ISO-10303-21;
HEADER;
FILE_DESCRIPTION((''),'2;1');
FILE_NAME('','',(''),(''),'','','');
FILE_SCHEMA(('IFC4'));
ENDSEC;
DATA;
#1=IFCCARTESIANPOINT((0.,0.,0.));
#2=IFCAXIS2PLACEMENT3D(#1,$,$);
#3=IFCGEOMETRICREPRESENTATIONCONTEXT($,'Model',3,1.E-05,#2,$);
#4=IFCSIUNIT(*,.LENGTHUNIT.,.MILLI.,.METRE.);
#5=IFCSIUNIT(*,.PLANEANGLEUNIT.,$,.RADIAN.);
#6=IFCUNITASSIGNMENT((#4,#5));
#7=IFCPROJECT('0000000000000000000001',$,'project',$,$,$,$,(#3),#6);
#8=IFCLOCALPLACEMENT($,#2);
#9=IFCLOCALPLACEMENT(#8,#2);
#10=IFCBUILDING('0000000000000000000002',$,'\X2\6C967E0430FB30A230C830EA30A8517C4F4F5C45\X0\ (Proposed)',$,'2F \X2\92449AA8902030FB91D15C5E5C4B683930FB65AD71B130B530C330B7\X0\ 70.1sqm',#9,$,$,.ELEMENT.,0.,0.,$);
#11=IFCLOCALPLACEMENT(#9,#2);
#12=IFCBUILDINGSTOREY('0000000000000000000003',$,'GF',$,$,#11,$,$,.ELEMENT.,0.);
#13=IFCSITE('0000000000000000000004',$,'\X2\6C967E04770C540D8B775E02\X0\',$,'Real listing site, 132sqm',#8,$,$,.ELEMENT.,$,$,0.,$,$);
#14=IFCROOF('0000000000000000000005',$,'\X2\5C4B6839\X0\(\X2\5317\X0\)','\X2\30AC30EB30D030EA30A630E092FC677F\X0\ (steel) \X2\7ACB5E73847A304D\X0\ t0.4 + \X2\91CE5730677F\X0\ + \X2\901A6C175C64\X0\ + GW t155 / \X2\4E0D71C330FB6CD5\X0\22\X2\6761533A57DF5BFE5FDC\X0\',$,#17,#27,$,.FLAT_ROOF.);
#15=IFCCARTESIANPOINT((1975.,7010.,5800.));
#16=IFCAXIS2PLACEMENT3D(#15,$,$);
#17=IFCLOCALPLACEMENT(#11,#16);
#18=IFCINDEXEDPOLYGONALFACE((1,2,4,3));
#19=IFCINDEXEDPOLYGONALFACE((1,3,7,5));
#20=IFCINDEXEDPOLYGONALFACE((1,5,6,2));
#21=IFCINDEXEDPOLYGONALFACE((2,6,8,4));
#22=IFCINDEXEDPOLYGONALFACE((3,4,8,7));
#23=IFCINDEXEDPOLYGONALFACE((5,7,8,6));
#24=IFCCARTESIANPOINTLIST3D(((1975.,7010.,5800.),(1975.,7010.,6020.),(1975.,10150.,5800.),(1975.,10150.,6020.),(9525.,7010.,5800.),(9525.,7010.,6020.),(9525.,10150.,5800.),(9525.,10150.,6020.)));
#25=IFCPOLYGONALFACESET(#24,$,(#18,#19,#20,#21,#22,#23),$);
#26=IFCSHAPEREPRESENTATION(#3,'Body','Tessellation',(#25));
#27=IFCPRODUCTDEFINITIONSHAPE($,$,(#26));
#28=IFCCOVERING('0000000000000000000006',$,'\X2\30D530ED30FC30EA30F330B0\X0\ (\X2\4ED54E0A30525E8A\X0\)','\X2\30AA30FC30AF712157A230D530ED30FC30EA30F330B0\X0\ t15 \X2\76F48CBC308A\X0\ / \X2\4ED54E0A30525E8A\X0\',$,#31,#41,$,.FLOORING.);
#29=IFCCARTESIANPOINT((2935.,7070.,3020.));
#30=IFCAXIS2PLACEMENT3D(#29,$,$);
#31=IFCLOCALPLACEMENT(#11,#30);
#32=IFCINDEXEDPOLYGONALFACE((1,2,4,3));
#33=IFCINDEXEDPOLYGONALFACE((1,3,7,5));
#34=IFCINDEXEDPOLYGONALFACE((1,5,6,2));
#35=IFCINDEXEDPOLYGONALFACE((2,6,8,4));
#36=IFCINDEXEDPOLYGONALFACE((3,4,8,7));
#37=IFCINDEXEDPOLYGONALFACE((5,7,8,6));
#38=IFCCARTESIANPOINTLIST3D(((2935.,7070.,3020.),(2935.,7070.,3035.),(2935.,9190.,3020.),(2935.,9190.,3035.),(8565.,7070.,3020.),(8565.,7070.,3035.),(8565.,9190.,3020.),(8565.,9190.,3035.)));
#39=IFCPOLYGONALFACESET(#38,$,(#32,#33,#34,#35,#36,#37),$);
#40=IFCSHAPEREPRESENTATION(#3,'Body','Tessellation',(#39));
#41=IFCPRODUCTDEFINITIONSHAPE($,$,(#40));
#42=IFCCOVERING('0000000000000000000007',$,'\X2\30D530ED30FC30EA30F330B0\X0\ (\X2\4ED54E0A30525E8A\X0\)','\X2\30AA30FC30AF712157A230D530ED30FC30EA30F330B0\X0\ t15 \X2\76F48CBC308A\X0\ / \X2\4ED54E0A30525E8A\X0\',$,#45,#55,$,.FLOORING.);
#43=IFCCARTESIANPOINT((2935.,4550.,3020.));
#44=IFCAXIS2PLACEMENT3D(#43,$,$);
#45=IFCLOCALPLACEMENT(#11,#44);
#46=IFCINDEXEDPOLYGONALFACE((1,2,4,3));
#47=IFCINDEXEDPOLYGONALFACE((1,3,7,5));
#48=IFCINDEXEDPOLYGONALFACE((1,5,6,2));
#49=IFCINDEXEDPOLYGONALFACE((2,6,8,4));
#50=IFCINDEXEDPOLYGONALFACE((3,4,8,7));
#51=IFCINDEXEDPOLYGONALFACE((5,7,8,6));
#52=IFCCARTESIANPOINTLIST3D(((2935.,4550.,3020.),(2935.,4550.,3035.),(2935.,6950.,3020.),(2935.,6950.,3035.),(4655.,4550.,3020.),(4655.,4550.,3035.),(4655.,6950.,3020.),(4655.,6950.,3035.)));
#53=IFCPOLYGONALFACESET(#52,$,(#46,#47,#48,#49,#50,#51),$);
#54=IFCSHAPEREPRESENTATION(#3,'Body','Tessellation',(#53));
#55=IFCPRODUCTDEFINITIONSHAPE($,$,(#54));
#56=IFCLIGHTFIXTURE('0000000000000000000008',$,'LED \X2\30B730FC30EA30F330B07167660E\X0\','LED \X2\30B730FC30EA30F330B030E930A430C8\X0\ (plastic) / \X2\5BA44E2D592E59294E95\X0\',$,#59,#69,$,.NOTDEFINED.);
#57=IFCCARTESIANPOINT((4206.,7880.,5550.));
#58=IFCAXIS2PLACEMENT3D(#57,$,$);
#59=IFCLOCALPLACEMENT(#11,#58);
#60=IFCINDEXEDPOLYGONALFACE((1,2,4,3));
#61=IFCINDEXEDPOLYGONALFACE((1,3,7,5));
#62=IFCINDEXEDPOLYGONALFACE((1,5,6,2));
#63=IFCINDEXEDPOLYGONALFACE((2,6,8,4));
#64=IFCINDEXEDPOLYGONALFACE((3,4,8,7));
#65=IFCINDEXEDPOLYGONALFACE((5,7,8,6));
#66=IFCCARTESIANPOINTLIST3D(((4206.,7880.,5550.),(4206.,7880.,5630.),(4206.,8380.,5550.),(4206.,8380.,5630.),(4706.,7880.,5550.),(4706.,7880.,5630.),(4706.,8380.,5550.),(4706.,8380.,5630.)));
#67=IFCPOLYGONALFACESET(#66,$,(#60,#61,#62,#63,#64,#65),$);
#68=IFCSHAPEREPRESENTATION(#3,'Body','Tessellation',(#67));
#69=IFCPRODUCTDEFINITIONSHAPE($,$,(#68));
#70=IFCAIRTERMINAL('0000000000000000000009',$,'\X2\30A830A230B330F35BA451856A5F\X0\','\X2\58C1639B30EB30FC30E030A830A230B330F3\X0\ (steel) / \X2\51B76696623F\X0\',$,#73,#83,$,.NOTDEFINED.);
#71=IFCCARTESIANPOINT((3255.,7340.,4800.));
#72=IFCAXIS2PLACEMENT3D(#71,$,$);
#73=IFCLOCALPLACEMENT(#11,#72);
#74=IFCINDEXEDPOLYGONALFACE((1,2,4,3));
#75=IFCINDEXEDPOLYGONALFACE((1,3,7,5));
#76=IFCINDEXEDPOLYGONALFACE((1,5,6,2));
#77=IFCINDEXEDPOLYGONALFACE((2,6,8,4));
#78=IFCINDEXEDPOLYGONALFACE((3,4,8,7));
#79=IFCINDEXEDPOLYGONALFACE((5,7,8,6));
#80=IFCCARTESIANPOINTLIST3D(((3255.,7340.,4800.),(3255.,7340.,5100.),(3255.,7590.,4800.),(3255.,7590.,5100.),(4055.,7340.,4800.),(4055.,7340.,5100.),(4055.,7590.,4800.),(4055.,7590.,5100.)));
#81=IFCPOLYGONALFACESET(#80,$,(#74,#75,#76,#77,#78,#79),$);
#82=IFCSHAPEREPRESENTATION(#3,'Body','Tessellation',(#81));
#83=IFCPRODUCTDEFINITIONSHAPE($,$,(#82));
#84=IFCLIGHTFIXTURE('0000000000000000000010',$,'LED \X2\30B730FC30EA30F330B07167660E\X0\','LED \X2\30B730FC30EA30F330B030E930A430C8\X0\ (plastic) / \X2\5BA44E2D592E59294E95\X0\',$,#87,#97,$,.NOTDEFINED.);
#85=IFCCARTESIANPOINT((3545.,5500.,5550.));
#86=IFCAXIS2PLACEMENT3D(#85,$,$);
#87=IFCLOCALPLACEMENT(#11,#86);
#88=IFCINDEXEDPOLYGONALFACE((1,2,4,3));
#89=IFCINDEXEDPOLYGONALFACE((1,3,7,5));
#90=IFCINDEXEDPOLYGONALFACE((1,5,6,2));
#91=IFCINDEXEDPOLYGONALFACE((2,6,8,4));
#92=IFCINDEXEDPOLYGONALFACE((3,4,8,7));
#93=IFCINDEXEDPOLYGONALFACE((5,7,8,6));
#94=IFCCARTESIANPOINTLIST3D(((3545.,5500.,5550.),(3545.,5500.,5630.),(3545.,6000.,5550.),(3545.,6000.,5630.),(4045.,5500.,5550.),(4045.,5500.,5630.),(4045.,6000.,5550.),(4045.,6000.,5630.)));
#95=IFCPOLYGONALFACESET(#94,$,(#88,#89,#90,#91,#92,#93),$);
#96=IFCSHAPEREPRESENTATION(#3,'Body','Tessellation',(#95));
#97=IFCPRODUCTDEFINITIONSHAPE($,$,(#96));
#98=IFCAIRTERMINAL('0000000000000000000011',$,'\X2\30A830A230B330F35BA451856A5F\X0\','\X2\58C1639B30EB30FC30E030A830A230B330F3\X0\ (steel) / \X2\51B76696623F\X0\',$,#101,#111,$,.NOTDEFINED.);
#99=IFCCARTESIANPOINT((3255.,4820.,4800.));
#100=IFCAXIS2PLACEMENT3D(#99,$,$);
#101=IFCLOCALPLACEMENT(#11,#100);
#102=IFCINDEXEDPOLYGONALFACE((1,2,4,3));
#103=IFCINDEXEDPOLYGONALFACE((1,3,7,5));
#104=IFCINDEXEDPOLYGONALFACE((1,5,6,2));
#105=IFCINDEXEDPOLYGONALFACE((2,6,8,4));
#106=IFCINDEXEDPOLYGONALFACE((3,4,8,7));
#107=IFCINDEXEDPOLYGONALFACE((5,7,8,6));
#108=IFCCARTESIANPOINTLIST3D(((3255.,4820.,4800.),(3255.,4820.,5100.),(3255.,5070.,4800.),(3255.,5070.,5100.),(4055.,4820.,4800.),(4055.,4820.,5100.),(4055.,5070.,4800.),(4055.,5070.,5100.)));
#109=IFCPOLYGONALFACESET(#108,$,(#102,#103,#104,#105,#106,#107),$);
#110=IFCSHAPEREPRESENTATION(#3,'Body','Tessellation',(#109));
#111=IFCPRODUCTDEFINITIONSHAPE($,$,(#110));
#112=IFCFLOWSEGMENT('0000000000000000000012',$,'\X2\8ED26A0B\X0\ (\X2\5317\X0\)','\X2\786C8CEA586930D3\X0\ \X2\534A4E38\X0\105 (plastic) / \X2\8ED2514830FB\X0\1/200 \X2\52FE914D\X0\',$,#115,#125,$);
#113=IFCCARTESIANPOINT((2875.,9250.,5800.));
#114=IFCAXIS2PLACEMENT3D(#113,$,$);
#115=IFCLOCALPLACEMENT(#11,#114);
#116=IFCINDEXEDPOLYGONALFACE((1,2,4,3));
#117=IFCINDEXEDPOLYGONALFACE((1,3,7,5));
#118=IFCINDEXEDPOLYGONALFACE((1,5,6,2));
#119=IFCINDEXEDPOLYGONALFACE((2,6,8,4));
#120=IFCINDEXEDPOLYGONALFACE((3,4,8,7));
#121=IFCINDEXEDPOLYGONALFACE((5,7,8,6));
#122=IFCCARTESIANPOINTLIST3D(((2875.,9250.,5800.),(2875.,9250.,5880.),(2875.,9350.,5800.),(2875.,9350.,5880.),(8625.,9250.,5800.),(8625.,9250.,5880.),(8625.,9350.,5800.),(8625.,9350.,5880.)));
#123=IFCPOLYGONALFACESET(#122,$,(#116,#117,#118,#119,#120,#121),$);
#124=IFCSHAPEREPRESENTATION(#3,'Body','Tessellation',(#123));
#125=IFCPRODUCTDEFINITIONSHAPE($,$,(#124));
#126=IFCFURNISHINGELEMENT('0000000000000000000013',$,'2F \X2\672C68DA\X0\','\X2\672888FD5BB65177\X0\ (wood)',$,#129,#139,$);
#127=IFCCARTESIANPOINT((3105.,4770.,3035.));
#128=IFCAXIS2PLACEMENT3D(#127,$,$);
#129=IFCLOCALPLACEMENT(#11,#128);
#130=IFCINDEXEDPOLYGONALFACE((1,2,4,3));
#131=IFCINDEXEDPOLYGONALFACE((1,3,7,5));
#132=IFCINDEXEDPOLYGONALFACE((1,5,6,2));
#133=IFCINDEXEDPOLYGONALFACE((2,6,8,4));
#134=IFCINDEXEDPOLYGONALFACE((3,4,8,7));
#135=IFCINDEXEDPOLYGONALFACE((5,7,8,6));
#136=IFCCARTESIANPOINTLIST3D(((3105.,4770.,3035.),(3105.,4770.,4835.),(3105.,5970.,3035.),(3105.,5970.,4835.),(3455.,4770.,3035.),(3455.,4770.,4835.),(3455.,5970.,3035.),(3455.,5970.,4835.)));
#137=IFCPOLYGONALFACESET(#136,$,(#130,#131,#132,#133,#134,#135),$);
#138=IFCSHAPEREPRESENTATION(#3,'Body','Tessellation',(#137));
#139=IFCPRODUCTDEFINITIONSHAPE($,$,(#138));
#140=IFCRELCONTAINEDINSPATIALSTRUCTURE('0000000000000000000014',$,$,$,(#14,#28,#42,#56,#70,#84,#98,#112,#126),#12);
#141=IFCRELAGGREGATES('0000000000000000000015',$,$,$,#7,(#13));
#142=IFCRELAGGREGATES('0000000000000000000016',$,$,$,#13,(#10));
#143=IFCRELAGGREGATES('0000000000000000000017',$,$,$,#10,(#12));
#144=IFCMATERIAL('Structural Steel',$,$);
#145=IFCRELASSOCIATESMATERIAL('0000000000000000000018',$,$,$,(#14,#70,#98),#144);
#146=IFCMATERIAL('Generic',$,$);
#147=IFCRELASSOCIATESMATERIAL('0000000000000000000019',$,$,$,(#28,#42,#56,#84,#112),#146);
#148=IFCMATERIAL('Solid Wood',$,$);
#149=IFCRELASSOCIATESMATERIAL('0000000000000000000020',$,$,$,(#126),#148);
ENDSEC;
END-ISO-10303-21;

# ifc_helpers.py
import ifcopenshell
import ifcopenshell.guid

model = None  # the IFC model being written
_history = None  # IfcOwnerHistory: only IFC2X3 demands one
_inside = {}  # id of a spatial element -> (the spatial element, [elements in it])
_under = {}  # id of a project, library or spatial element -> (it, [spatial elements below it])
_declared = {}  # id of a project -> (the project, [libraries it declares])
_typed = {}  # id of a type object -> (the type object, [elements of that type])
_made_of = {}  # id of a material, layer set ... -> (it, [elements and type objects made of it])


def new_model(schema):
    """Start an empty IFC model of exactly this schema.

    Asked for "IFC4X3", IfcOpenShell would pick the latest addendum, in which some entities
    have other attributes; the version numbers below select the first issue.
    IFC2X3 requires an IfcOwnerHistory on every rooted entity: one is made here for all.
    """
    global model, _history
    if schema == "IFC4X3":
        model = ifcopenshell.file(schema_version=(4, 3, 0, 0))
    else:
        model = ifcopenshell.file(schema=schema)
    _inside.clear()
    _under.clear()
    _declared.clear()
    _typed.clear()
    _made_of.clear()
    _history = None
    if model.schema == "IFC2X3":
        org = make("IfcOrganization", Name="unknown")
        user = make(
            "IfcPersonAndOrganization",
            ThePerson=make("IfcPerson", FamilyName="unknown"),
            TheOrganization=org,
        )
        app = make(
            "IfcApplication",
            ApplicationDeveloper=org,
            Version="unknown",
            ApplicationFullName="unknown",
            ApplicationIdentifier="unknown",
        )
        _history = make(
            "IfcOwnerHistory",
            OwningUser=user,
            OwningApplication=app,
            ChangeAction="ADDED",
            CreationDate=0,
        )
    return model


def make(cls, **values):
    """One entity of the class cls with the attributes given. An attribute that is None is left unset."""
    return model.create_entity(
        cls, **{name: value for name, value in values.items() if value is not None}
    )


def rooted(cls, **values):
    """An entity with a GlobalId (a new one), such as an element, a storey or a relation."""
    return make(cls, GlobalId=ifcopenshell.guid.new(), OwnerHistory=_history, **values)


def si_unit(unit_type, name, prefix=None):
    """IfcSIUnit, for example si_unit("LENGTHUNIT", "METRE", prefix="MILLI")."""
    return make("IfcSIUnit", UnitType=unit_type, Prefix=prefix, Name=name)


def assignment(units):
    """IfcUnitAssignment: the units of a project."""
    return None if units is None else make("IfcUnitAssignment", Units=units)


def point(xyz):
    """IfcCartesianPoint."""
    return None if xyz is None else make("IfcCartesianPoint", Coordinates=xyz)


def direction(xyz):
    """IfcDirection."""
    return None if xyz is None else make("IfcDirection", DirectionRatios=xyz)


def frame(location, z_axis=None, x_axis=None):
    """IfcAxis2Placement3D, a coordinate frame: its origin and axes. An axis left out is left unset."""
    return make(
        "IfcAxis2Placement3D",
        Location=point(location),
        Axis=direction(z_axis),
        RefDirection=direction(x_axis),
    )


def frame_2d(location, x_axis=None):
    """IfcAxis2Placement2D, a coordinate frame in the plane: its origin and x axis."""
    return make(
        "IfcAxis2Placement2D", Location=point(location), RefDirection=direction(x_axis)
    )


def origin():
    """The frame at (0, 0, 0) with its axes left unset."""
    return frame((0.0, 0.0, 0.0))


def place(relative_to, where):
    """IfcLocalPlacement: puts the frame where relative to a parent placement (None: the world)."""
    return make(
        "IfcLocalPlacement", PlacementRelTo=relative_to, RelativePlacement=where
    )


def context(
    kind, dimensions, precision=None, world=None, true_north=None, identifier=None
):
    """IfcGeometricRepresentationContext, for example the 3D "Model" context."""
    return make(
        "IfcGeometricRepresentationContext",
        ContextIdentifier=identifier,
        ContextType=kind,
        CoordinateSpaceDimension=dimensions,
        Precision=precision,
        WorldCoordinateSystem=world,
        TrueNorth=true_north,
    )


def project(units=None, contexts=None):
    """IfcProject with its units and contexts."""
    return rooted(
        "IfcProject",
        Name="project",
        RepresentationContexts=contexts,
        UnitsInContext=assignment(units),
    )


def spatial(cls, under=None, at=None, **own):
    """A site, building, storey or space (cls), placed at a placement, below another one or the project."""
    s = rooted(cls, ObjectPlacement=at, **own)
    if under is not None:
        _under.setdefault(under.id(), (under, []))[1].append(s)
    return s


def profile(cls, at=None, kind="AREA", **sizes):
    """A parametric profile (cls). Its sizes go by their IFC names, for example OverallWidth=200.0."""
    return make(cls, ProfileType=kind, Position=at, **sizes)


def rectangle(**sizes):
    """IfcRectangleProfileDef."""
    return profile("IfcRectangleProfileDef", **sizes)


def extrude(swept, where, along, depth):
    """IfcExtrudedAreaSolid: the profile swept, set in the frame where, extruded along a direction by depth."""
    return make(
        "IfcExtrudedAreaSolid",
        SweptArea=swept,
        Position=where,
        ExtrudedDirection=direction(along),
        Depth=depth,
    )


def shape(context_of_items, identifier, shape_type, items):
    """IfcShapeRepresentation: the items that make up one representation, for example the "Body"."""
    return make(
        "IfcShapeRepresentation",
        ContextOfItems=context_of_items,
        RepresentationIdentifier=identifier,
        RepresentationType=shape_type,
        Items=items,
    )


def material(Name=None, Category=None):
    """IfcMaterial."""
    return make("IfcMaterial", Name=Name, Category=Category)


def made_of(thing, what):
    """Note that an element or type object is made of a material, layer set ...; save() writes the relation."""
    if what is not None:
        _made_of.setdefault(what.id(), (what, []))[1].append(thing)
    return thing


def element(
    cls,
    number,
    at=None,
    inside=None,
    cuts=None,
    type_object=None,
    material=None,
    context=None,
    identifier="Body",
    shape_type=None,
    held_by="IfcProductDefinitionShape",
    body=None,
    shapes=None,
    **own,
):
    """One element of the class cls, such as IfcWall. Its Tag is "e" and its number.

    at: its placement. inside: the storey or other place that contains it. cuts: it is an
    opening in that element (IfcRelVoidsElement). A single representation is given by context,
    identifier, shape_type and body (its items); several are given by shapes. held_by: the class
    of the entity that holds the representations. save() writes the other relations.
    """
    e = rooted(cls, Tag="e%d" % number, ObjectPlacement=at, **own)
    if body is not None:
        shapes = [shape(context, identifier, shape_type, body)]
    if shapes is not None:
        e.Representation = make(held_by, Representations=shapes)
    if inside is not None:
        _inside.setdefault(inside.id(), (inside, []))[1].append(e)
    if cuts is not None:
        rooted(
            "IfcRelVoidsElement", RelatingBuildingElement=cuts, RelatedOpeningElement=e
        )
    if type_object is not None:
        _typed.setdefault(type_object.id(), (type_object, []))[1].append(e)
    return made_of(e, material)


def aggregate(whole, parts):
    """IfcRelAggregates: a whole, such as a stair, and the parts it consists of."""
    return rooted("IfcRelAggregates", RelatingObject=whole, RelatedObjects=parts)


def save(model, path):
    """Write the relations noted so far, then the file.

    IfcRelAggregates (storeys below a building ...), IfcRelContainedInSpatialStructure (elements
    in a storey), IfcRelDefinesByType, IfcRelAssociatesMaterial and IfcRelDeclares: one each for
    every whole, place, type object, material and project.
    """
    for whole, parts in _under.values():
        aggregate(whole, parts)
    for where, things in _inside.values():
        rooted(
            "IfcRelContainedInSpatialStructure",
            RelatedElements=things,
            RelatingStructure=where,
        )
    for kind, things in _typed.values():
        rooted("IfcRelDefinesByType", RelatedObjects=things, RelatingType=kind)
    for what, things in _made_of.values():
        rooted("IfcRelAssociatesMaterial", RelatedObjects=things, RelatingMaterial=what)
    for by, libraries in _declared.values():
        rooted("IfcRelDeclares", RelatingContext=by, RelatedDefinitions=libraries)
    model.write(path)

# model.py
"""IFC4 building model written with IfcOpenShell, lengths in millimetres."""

from ifc_helpers import new_model, si_unit, frame, frame_2d, origin, place, context, project, spatial, rectangle, extrude, material, element, save


model = new_model("IFC4")

# Units and contexts
model_context = context("Model", 3, precision=1e-05, world=origin())
ifc_project = project(units=[si_unit("LENGTHUNIT", "METRE", prefix="MILLI"), si_unit("PLANEANGLEUNIT", "RADIAN")], contexts=[model_context])

# Site, building, storey
site_placement = place(None, origin())
site = spatial("IfcSite", under=ifc_project, at=site_placement, Name="沖縄県名護市", ObjectType="Real listing site, 132sqm", CompositionType="ELEMENT", RefElevation=0.0)
building_placement = place(site_placement, origin())
building = spatial("IfcBuilding", under=site, at=building_placement, Name="沖縄・アトリエ兼住居 (Proposed)", ObjectType="2F 鉄骨造・金属屋根・断熱サッシ 70.1sqm", CompositionType="ELEMENT", ElevationOfRefHeight=0.0, ElevationOfTerrain=0.0)
storey_placement = place(building_placement, origin())
storey = spatial("IfcBuildingStorey", under=building, at=storey_placement, Name="GF", CompositionType="ELEMENT", Elevation=0.0)

# Shared definitions
ifc_material_1 = material(Name="Solid Wood")

# Roof
ifc_material_2 = material(Name="Structural Steel")
for number, where, name in (
    (1, (1975.0, 7010.0, 5800.0), "屋根(北)"),
):
    element("IfcRoof", number, at=place(storey_placement, frame(where)), inside=storey, material=ifc_material_2, Name=name, Description="ガルバリウム鋼板 (steel) 立平葺き t0.4 + 野地板 + 通気層 + GW t155 / 不燃・法22条区域対応", PredefinedType="FLAT_ROOF", context=model_context, shape_type="SweptSolid", body=[
        extrude(rectangle(XDim=7550.0, YDim=3140.0, at=frame_2d((3775.0, 1570.0))), frame((1975.0, 7010.0, 5800.0)), (0.0, 0.0, 1.0), 220.0),
    ])

# Coverings
ifc_material_3 = material(Name="Generic")
covering_1_placement = place(storey_placement, frame((2935.0, 7070.0, 3020.0)))
element("IfcCovering", 2, at=covering_1_placement, inside=storey, material=ifc_material_3, Name="フローリング (仕上げ床)", Description="オーク無垢フローリング t15 直貼り / 仕上げ床", PredefinedType="FLOORING", context=model_context, shape_type="SweptSolid", body=[
    extrude(rectangle(XDim=5630.0, YDim=2120.0, at=frame_2d((2815.0, 1060.0))), frame((2935.0, 7070.0, 3020.0)), (0.0, 0.0, 1.0), 15.0),
])
covering_2_placement = place(storey_placement, frame((2935.0, 4550.0, 3020.0)))
element("IfcCovering", 3, at=covering_2_placement, inside=storey, material=ifc_material_3, Name="フローリング (仕上げ床)", Description="オーク無垢フローリング t15 直貼り / 仕上げ床", PredefinedType="FLOORING", context=model_context, shape_type="SweptSolid", body=[
    extrude(rectangle(XDim=1720.0, YDim=2400.0, at=frame_2d((860.0, 1200.0))), frame((2935.0, 4550.0, 3020.0)), (0.0, 0.0, 1.0), 15.0),
])

# Light fixture
light_fixture_1_placement = place(storey_placement, frame((4206.0, 7880.0, 5550.0)))
element("IfcLightFixture", 4, at=light_fixture_1_placement, inside=storey, material=ifc_material_3, Name="LED シーリング照明", Description="LED シーリングライト (plastic) / 室中央天井", PredefinedType="NOTDEFINED", context=model_context, shape_type="SweptSolid", body=[
    extrude(rectangle(XDim=500.0, YDim=500.0, at=frame_2d((250.0, 250.0))), frame((4206.0, 7880.0, 5550.0)), (0.0, 0.0, 1.0), 80.0),
])

# Air terminal
air_terminal_1_placement = place(storey_placement, frame((3255.0, 7340.0, 4800.0)))
element("IfcAirTerminal", 5, at=air_terminal_1_placement, inside=storey, material=ifc_material_2, Name="エアコン室内機", Description="壁掛ルームエアコン (steel) / 冷暖房", PredefinedType="NOTDEFINED", context=model_context, shape_type="SweptSolid", body=[
    extrude(rectangle(XDim=800.0, YDim=250.0, at=frame_2d((400.0, 125.0))), frame((3255.0, 7340.0, 4800.0)), (0.0, 0.0, 1.0), 300.0),
])

# Light fixture
light_fixture_2_placement = place(storey_placement, frame((3545.0, 5500.0, 5550.0)))
element("IfcLightFixture", 6, at=light_fixture_2_placement, inside=storey, material=ifc_material_3, Name="LED シーリング照明", Description="LED シーリングライト (plastic) / 室中央天井", PredefinedType="NOTDEFINED", context=model_context, shape_type="SweptSolid", body=[
    extrude(rectangle(XDim=500.0, YDim=500.0, at=frame_2d((250.0, 250.0))), frame((3545.0, 5500.0, 5550.0)), (0.0, 0.0, 1.0), 80.0),
])

# Air terminal
air_terminal_2_placement = place(storey_placement, frame((3255.0, 4820.0, 4800.0)))
element("IfcAirTerminal", 7, at=air_terminal_2_placement, inside=storey, material=ifc_material_2, Name="エアコン室内機", Description="壁掛ルームエアコン (steel) / 冷暖房", PredefinedType="NOTDEFINED", context=model_context, shape_type="SweptSolid", body=[
    extrude(rectangle(XDim=800.0, YDim=250.0, at=frame_2d((400.0, 125.0))), frame((3255.0, 4820.0, 4800.0)), (0.0, 0.0, 1.0), 300.0),
])

# Flow segment
flow_segment_placement = place(storey_placement, frame((2875.0, 9250.0, 5800.0)))
element("IfcFlowSegment", 8, at=flow_segment_placement, inside=storey, material=ifc_material_3, Name="軒樋 (北)", Description="硬質塩ビ 半丸105 (plastic) / 軒先・1/200 勾配", context=model_context, shape_type="SweptSolid", body=[
    extrude(rectangle(XDim=5750.0, YDim=100.0, at=frame_2d((2875.0, 50.0))), frame((2875.0, 9250.0, 5800.0)), (0.0, 0.0, 1.0), 80.0),
])

# Furnishing element
furnishing_placement = place(storey_placement, frame((3105.0, 4770.0, 3035.0)))
element("IfcFurnishingElement", 9, at=furnishing_placement, inside=storey, material=ifc_material_1, Name="2F 本棚", Description="木製家具 (wood)", context=model_context, shape_type="SweptSolid", body=[
    extrude(rectangle(XDim=350.0, YDim=1200.0, at=frame_2d((175.0, 600.0))), frame((3105.0, 4770.0, 3035.0)), (0.0, 0.0, 1.0), 1800.0),
])

save(model, "model.ifc")
